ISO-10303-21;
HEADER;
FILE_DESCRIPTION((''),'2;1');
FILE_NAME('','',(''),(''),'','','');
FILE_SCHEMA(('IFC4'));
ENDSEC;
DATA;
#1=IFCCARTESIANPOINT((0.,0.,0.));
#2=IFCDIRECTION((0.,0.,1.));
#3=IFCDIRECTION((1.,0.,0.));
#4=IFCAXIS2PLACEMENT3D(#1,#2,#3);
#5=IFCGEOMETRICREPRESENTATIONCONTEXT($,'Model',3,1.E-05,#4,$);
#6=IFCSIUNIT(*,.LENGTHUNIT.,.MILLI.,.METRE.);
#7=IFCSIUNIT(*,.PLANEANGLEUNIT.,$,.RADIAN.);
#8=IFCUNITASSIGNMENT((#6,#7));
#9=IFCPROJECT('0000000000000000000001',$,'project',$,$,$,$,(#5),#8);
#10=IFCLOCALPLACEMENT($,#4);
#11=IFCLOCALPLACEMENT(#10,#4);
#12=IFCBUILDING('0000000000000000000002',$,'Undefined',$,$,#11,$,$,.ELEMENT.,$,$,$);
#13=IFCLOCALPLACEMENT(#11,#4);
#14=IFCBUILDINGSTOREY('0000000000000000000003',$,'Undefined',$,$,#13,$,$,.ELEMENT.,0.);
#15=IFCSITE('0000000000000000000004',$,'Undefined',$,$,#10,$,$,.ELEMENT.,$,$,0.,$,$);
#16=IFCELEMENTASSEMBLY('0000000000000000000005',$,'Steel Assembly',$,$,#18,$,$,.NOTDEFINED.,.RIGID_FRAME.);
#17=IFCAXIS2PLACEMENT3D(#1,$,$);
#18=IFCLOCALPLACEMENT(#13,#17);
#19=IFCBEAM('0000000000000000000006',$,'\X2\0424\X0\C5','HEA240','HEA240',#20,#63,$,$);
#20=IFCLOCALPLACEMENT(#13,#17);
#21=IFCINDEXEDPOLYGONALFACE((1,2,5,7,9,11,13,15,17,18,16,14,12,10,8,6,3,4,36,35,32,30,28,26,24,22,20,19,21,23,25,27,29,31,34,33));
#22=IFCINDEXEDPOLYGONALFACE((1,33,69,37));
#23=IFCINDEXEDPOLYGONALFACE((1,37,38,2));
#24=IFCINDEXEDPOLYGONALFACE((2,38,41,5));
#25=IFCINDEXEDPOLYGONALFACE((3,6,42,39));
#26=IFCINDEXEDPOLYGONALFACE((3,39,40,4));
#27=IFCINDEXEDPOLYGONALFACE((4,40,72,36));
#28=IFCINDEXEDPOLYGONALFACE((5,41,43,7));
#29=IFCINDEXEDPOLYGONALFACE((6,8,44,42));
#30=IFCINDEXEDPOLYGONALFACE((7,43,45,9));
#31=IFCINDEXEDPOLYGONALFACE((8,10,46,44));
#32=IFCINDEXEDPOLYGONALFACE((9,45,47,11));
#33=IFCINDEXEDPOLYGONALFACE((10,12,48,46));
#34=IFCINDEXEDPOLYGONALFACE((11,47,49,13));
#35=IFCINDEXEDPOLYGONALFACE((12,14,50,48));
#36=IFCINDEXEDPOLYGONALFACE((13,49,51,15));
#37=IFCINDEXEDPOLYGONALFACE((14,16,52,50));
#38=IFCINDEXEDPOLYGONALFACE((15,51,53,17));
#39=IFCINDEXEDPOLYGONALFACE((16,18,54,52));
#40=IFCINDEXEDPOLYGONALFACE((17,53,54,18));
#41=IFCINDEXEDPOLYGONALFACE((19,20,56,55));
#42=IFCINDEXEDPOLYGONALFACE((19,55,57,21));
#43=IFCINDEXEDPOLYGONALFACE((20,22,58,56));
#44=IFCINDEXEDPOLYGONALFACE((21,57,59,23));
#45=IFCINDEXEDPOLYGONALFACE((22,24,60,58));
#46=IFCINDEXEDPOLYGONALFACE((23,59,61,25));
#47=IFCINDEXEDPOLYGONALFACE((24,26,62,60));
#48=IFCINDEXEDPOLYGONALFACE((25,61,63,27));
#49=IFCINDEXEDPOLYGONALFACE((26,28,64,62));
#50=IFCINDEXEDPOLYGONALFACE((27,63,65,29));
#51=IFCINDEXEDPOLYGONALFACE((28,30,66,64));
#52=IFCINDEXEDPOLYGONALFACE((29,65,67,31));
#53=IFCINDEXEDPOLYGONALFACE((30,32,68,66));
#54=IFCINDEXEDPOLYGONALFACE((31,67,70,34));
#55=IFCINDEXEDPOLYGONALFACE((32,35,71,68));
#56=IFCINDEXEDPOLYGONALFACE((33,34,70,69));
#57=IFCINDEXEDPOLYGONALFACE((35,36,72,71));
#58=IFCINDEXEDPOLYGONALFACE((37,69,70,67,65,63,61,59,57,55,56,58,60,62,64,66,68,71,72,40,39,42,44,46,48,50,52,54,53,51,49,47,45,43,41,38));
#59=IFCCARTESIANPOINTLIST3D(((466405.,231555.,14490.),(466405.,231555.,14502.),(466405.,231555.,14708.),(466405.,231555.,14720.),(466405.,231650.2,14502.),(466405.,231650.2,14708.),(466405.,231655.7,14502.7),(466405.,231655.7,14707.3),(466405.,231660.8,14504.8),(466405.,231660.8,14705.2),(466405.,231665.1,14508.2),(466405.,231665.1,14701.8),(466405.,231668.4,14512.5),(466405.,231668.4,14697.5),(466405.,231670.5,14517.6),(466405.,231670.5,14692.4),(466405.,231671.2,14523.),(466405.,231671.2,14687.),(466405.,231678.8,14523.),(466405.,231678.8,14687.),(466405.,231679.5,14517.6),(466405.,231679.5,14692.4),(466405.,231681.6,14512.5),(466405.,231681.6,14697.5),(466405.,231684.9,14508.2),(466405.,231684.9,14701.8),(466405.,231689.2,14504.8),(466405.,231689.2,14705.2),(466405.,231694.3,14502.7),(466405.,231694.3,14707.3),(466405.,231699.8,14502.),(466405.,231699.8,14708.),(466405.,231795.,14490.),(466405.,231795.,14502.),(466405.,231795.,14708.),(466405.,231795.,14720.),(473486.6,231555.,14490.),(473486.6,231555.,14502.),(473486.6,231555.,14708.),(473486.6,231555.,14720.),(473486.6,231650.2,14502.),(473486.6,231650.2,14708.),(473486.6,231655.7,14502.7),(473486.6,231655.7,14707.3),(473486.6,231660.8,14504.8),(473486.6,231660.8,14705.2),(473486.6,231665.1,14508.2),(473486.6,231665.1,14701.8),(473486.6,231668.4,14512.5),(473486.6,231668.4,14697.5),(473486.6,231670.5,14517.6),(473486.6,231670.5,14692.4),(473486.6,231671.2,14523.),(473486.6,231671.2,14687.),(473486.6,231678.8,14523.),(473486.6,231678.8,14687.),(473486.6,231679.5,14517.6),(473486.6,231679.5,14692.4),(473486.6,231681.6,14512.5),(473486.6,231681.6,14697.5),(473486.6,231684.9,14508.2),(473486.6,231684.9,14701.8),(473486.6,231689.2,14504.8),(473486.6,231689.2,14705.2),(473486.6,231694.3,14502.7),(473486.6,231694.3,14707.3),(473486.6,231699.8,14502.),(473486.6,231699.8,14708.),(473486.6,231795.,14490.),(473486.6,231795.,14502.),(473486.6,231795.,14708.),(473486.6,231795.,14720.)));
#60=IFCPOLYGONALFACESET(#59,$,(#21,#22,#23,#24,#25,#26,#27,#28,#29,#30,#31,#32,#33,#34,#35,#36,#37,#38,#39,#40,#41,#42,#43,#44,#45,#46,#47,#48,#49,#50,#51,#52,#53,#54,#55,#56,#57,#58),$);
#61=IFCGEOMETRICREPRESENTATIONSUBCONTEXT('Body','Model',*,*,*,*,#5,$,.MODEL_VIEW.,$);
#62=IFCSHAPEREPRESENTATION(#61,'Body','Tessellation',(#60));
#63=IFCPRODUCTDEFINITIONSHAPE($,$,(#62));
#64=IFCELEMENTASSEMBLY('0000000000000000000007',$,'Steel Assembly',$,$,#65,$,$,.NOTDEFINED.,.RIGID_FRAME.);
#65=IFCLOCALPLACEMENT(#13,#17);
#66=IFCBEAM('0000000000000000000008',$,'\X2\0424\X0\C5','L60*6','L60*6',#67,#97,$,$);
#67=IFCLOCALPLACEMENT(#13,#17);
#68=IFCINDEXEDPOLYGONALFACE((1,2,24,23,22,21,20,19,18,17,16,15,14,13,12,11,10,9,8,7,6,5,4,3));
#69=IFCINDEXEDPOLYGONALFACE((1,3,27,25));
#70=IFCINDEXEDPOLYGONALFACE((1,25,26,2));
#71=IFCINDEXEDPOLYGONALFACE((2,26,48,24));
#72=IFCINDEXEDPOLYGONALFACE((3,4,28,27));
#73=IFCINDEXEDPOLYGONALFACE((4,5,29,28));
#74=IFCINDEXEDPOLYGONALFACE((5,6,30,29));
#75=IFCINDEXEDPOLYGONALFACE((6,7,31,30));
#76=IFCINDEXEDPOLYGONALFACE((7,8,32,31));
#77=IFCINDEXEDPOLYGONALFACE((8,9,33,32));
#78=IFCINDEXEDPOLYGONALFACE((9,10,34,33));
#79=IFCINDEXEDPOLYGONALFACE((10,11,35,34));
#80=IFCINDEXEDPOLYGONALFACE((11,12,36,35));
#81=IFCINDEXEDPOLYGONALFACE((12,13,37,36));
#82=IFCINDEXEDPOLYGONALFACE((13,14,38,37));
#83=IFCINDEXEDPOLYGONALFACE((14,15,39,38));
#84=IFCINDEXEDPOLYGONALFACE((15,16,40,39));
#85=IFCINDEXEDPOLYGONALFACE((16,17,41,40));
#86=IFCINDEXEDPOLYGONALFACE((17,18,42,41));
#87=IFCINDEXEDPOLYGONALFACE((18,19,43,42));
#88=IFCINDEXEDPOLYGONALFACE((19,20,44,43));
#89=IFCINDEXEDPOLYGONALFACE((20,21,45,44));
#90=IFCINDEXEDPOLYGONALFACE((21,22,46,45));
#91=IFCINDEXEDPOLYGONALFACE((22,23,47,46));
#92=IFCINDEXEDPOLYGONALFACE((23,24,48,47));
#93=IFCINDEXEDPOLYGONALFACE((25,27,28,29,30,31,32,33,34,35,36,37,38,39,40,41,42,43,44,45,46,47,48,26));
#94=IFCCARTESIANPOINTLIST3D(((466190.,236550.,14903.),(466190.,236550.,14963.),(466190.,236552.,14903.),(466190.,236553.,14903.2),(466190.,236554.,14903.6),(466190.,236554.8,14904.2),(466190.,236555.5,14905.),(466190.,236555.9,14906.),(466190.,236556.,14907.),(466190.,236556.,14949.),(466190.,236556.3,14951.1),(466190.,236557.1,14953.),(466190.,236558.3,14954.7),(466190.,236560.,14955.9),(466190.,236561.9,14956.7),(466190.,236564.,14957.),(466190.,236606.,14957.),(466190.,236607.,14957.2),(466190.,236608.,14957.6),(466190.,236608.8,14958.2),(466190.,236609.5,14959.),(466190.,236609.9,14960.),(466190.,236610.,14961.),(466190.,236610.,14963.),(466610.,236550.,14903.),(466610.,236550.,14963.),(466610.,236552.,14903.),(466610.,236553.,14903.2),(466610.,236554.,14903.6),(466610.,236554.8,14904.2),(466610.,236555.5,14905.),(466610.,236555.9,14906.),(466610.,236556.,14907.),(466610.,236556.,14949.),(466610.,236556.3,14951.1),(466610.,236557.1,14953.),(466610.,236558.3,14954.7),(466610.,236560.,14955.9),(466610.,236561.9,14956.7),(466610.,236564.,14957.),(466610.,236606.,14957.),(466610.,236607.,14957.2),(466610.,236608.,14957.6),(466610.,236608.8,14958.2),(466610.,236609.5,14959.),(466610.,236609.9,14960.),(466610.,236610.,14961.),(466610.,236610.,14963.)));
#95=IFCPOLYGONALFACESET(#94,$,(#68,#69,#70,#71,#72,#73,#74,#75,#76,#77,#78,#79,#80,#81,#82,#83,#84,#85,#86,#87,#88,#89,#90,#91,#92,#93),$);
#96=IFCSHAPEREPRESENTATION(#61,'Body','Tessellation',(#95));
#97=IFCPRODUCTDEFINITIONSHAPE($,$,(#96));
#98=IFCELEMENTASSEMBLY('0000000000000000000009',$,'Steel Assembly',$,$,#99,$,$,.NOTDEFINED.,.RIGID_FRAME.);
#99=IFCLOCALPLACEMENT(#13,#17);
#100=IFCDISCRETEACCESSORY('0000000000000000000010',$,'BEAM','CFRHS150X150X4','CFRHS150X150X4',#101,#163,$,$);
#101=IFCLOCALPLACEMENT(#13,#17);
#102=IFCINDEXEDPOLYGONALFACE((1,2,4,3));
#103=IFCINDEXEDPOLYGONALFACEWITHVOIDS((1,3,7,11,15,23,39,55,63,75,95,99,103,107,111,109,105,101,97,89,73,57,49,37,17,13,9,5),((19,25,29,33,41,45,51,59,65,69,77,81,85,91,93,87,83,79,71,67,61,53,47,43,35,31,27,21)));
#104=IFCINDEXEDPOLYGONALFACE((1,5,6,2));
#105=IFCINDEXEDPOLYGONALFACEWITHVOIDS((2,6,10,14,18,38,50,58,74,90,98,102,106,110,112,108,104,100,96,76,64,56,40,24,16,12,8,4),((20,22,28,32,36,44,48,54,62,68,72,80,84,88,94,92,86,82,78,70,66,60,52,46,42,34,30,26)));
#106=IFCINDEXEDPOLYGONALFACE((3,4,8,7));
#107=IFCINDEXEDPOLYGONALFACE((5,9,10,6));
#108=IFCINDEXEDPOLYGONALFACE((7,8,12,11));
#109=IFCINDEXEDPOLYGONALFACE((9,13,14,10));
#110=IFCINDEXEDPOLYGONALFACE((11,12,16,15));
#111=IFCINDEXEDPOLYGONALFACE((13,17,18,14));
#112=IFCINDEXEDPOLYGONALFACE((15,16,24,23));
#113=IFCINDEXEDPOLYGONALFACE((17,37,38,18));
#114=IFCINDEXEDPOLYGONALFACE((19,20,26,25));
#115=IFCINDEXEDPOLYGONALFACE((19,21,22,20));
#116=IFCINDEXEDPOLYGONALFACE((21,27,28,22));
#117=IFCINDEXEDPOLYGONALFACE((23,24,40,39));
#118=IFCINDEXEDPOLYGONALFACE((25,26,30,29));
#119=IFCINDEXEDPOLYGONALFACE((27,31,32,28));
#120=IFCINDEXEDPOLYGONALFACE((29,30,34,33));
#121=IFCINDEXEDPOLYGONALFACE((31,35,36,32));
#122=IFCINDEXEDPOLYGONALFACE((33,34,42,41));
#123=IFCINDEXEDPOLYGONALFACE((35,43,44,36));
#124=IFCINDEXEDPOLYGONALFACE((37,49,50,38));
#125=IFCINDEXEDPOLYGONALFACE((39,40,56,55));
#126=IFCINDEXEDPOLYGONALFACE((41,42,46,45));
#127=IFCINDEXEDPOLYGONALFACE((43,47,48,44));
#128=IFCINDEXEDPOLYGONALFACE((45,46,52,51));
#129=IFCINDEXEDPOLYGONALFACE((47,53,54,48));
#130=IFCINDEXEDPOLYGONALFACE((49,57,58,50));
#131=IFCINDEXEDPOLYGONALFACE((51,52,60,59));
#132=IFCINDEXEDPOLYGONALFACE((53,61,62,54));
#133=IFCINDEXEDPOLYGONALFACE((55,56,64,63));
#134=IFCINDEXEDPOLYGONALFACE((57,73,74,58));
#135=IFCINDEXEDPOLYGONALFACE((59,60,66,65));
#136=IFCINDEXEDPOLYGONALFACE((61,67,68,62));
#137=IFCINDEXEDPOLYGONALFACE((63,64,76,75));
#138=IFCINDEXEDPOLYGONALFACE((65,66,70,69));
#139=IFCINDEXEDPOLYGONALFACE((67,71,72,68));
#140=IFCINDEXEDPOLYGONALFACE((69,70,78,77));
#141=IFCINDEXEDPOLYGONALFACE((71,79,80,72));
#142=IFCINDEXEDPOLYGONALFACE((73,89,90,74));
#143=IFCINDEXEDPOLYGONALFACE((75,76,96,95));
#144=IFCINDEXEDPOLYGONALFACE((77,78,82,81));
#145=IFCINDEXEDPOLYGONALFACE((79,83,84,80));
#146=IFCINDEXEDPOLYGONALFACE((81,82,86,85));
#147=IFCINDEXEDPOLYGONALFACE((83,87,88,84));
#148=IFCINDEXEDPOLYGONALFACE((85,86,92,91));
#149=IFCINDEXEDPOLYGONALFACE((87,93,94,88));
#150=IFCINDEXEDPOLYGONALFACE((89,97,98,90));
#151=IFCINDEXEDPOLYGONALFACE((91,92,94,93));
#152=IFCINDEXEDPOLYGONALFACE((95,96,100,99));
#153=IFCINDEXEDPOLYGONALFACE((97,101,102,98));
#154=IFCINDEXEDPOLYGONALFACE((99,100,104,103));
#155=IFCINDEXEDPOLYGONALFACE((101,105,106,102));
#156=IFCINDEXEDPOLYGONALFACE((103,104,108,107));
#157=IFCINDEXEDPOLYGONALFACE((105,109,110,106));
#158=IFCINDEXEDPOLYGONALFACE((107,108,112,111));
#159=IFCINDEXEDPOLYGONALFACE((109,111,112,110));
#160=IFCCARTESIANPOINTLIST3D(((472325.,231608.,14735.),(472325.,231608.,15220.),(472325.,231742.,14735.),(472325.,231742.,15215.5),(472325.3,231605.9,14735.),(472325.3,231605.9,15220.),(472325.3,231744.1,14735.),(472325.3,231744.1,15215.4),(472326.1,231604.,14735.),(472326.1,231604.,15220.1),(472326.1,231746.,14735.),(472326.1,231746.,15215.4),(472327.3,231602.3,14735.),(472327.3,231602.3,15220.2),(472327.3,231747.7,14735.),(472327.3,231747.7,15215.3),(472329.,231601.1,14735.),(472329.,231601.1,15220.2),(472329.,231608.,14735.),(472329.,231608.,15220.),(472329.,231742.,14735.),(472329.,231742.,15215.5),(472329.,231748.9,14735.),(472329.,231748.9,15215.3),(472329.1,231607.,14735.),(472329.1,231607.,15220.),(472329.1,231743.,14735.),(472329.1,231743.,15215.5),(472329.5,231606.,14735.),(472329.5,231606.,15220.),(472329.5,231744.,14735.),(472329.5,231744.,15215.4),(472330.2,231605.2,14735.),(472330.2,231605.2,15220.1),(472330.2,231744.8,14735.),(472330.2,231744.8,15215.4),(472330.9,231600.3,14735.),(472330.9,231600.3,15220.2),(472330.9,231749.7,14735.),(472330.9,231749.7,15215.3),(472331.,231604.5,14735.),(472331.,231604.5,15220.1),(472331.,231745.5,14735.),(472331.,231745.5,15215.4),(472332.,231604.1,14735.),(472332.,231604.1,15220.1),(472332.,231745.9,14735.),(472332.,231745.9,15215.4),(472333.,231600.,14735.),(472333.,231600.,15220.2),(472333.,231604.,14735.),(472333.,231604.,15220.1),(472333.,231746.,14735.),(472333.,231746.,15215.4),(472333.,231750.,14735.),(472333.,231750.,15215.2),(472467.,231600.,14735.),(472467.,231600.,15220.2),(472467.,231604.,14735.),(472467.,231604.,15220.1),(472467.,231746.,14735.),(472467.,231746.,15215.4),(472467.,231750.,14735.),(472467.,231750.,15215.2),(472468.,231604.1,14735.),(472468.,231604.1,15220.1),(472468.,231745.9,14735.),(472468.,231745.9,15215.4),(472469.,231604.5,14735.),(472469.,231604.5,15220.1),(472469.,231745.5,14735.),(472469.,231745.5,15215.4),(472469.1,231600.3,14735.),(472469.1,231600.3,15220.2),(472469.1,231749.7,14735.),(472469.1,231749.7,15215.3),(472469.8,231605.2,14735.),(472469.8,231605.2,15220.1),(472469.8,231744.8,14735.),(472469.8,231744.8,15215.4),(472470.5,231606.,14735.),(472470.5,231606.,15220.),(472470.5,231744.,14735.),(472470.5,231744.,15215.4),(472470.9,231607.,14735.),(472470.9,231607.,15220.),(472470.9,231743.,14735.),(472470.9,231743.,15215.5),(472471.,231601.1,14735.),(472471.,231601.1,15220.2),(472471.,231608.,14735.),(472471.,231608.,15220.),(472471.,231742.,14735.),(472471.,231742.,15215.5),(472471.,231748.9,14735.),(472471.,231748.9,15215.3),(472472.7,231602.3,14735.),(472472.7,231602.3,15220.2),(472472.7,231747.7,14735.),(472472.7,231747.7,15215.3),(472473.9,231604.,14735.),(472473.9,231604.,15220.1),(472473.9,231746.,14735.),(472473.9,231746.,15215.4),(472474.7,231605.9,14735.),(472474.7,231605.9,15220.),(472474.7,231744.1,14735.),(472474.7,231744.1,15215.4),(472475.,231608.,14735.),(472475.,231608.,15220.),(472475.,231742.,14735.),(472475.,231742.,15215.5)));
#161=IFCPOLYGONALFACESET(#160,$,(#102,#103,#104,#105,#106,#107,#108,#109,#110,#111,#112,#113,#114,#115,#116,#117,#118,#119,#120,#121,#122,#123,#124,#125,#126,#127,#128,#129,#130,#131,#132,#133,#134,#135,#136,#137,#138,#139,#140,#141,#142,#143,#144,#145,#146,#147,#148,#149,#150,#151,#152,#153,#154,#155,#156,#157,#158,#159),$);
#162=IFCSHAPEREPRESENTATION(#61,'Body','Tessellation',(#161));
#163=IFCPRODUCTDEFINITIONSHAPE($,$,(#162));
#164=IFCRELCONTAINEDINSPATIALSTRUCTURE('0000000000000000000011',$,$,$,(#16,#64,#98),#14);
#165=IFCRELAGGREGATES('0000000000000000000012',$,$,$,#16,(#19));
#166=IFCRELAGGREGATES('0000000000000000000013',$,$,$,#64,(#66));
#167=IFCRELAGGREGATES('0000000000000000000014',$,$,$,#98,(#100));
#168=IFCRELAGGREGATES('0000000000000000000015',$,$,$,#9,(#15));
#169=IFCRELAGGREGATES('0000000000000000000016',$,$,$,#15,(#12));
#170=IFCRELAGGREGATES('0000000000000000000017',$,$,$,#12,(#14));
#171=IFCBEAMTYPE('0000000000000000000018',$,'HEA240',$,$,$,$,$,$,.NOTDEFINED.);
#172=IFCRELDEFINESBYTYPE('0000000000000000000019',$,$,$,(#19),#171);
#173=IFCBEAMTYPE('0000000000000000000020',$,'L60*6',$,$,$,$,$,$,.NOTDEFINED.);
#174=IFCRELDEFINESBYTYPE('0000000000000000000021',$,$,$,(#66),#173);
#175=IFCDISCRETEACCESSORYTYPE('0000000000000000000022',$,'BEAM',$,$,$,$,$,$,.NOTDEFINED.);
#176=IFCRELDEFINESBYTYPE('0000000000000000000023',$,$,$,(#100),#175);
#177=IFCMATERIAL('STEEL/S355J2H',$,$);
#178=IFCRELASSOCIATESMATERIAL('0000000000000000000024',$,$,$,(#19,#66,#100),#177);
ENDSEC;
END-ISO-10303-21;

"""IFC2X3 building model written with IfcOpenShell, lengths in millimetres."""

from ifc_helpers import new_model, si_unit, frame, origin_with_axes, origin_2d_with_axis, place, context, subcontext, project, spatial, hollow_rectangle, i_section, l_section, extrude, clip, halfspace, material, type_object, element, aggregate, save


model = new_model("IFC2X3")

# Units and contexts
model_context = context("Model", 3, precision=1e-05, world=origin_with_axes())
body_context = subcontext(model_context, "Body", "Model", "MODEL_VIEW")
ifc_project = project(units=[si_unit("LENGTHUNIT", "METRE", prefix="MILLI"), si_unit("PLANEANGLEUNIT", "RADIAN")], contexts=[model_context])

# Site, building, storey
site_placement = place(None, origin_with_axes())
site = spatial("IfcSite", under=ifc_project, at=site_placement, Name="Undefined", CompositionType="ELEMENT", RefElevation=0.0)
building_placement = place(site_placement, origin_with_axes())
building = spatial("IfcBuilding", under=site, at=building_placement, Name="Undefined", CompositionType="ELEMENT")
storey_placement = place(building_placement, origin_with_axes())
storey = spatial("IfcBuildingStorey", under=building, at=storey_placement, Name="Undefined", CompositionType="ELEMENT", Elevation=0.0)

# Element assemblies, beams
ifc_material_1 = material(Name="STEEL/S355J2H")
beam_type_1 = type_object("IfcBeamType", Name="HEA240", PredefinedType="NOTDEFINED")
assembly_1_placement = place(storey_placement, origin_with_axes())
assembly_1 = element("IfcElementAssembly", 1, at=assembly_1_placement, inside=storey, Name="Steel Assembly", AssemblyPlace="NOTDEFINED", PredefinedType="RIGID_FRAME")
beam_1_placement = place(assembly_1_placement, frame((466405.0, 231675.0, 14605.0), z_axis=(0.0, 0.0, 1.0), x_axis=(1.0, 0.0, 0.0)))
beam_1 = element("IfcBeam", 2, at=beam_1_placement, type_object=beam_type_1, material=ifc_material_1, Name="ФC5", Description="HEA240", ObjectType="HEA240", context=body_context, shape_type="SweptSolid", body=[
    extrude(i_section(OverallWidth=240.0, OverallDepth=230.0, WebThickness=7.5, FlangeThickness=12.0, FilletRadius=21.0, at=origin_2d_with_axis()), frame((7081.6, 0.0, 0.0), z_axis=(-1.0, 0.0, 0.0), x_axis=(0.0, -1.0, 0.0)), (0.0, 0.0, 1.0), 7081.6),
])
aggregate(assembly_1, [beam_1])
assembly_2_placement = place(storey_placement, origin_with_axes())
assembly_2 = element("IfcElementAssembly", 3, at=assembly_2_placement, inside=storey, Name="Steel Assembly", AssemblyPlace="NOTDEFINED", PredefinedType="RIGID_FRAME")
beam_type_2 = type_object("IfcBeamType", Name="L60*6", PredefinedType="NOTDEFINED")
beam_2_placement = place(assembly_2_placement, frame((466610.0, 236580.0, 14933.0), z_axis=(0.0, 1.0, 0.0), x_axis=(-1.0, 0.0, 0.0)))
beam_2 = element("IfcBeam", 4, at=beam_2_placement, type_object=beam_type_2, material=ifc_material_1, Name="ФC5", Description="L60*6", ObjectType="L60*6", context=body_context, shape_type="SweptSolid", body=[
    extrude(l_section(Depth=60.0, Width=60.0, Thickness=6.0, FilletRadius=8.0, EdgeRadius=4.0, at=origin_2d_with_axis()), frame((420.0, 0.0, 0.0), z_axis=(-1.0, 0.0, 0.0), x_axis=(0.0, -1.0, 0.0)), (0.0, 0.0, 1.0), 420.0),
])
aggregate(assembly_2, [beam_2])

# Element assembly, discrete accessory
assembly_3_placement = place(storey_placement, origin_with_axes())
assembly_3 = element("IfcElementAssembly", 5, at=assembly_3_placement, inside=storey, Name="Steel Assembly", AssemblyPlace="NOTDEFINED", PredefinedType="RIGID_FRAME")
discrete_accessory_type_1 = type_object("IfcDiscreteAccessoryType", Name="BEAM")
discrete_accessory_1_placement = place(assembly_3_placement, frame((472400.0, 231675.0, 14720.0), z_axis=(0.0, 0.0, 1.0), x_axis=(1.0, 0.0, 0.0)))
discrete_accessory_1 = element("IfcDiscreteAccessory", 6, at=discrete_accessory_1_placement, type_object=discrete_accessory_type_1, material=ifc_material_1, Name="BEAM", Description="CFRHS150X150X4", ObjectType="CFRHS150X150X4", context=body_context, shape_type="Clipping", body=[
    clip(extrude(hollow_rectangle(XDim=150.0, YDim=150.0, WallThickness=4.0, InnerFilletRadius=4.0, OuterFilletRadius=8.0, at=origin_2d_with_axis()), frame((0.0, 0.0, 500.3), z_axis=(0.0, 0.0, -1.0), x_axis=(0.0, -1.0, 0.0)), (0.0, 0.0, 1.0), 485.3), halfspace(frame((-1000.0, -2.7, 497.8), z_axis=(0.0, -0.033315, -0.999445), x_axis=(0.0, -0.999445, 0.033315)), True)),
])
aggregate(assembly_3, [discrete_accessory_1])

save(model, "model.ifc")
